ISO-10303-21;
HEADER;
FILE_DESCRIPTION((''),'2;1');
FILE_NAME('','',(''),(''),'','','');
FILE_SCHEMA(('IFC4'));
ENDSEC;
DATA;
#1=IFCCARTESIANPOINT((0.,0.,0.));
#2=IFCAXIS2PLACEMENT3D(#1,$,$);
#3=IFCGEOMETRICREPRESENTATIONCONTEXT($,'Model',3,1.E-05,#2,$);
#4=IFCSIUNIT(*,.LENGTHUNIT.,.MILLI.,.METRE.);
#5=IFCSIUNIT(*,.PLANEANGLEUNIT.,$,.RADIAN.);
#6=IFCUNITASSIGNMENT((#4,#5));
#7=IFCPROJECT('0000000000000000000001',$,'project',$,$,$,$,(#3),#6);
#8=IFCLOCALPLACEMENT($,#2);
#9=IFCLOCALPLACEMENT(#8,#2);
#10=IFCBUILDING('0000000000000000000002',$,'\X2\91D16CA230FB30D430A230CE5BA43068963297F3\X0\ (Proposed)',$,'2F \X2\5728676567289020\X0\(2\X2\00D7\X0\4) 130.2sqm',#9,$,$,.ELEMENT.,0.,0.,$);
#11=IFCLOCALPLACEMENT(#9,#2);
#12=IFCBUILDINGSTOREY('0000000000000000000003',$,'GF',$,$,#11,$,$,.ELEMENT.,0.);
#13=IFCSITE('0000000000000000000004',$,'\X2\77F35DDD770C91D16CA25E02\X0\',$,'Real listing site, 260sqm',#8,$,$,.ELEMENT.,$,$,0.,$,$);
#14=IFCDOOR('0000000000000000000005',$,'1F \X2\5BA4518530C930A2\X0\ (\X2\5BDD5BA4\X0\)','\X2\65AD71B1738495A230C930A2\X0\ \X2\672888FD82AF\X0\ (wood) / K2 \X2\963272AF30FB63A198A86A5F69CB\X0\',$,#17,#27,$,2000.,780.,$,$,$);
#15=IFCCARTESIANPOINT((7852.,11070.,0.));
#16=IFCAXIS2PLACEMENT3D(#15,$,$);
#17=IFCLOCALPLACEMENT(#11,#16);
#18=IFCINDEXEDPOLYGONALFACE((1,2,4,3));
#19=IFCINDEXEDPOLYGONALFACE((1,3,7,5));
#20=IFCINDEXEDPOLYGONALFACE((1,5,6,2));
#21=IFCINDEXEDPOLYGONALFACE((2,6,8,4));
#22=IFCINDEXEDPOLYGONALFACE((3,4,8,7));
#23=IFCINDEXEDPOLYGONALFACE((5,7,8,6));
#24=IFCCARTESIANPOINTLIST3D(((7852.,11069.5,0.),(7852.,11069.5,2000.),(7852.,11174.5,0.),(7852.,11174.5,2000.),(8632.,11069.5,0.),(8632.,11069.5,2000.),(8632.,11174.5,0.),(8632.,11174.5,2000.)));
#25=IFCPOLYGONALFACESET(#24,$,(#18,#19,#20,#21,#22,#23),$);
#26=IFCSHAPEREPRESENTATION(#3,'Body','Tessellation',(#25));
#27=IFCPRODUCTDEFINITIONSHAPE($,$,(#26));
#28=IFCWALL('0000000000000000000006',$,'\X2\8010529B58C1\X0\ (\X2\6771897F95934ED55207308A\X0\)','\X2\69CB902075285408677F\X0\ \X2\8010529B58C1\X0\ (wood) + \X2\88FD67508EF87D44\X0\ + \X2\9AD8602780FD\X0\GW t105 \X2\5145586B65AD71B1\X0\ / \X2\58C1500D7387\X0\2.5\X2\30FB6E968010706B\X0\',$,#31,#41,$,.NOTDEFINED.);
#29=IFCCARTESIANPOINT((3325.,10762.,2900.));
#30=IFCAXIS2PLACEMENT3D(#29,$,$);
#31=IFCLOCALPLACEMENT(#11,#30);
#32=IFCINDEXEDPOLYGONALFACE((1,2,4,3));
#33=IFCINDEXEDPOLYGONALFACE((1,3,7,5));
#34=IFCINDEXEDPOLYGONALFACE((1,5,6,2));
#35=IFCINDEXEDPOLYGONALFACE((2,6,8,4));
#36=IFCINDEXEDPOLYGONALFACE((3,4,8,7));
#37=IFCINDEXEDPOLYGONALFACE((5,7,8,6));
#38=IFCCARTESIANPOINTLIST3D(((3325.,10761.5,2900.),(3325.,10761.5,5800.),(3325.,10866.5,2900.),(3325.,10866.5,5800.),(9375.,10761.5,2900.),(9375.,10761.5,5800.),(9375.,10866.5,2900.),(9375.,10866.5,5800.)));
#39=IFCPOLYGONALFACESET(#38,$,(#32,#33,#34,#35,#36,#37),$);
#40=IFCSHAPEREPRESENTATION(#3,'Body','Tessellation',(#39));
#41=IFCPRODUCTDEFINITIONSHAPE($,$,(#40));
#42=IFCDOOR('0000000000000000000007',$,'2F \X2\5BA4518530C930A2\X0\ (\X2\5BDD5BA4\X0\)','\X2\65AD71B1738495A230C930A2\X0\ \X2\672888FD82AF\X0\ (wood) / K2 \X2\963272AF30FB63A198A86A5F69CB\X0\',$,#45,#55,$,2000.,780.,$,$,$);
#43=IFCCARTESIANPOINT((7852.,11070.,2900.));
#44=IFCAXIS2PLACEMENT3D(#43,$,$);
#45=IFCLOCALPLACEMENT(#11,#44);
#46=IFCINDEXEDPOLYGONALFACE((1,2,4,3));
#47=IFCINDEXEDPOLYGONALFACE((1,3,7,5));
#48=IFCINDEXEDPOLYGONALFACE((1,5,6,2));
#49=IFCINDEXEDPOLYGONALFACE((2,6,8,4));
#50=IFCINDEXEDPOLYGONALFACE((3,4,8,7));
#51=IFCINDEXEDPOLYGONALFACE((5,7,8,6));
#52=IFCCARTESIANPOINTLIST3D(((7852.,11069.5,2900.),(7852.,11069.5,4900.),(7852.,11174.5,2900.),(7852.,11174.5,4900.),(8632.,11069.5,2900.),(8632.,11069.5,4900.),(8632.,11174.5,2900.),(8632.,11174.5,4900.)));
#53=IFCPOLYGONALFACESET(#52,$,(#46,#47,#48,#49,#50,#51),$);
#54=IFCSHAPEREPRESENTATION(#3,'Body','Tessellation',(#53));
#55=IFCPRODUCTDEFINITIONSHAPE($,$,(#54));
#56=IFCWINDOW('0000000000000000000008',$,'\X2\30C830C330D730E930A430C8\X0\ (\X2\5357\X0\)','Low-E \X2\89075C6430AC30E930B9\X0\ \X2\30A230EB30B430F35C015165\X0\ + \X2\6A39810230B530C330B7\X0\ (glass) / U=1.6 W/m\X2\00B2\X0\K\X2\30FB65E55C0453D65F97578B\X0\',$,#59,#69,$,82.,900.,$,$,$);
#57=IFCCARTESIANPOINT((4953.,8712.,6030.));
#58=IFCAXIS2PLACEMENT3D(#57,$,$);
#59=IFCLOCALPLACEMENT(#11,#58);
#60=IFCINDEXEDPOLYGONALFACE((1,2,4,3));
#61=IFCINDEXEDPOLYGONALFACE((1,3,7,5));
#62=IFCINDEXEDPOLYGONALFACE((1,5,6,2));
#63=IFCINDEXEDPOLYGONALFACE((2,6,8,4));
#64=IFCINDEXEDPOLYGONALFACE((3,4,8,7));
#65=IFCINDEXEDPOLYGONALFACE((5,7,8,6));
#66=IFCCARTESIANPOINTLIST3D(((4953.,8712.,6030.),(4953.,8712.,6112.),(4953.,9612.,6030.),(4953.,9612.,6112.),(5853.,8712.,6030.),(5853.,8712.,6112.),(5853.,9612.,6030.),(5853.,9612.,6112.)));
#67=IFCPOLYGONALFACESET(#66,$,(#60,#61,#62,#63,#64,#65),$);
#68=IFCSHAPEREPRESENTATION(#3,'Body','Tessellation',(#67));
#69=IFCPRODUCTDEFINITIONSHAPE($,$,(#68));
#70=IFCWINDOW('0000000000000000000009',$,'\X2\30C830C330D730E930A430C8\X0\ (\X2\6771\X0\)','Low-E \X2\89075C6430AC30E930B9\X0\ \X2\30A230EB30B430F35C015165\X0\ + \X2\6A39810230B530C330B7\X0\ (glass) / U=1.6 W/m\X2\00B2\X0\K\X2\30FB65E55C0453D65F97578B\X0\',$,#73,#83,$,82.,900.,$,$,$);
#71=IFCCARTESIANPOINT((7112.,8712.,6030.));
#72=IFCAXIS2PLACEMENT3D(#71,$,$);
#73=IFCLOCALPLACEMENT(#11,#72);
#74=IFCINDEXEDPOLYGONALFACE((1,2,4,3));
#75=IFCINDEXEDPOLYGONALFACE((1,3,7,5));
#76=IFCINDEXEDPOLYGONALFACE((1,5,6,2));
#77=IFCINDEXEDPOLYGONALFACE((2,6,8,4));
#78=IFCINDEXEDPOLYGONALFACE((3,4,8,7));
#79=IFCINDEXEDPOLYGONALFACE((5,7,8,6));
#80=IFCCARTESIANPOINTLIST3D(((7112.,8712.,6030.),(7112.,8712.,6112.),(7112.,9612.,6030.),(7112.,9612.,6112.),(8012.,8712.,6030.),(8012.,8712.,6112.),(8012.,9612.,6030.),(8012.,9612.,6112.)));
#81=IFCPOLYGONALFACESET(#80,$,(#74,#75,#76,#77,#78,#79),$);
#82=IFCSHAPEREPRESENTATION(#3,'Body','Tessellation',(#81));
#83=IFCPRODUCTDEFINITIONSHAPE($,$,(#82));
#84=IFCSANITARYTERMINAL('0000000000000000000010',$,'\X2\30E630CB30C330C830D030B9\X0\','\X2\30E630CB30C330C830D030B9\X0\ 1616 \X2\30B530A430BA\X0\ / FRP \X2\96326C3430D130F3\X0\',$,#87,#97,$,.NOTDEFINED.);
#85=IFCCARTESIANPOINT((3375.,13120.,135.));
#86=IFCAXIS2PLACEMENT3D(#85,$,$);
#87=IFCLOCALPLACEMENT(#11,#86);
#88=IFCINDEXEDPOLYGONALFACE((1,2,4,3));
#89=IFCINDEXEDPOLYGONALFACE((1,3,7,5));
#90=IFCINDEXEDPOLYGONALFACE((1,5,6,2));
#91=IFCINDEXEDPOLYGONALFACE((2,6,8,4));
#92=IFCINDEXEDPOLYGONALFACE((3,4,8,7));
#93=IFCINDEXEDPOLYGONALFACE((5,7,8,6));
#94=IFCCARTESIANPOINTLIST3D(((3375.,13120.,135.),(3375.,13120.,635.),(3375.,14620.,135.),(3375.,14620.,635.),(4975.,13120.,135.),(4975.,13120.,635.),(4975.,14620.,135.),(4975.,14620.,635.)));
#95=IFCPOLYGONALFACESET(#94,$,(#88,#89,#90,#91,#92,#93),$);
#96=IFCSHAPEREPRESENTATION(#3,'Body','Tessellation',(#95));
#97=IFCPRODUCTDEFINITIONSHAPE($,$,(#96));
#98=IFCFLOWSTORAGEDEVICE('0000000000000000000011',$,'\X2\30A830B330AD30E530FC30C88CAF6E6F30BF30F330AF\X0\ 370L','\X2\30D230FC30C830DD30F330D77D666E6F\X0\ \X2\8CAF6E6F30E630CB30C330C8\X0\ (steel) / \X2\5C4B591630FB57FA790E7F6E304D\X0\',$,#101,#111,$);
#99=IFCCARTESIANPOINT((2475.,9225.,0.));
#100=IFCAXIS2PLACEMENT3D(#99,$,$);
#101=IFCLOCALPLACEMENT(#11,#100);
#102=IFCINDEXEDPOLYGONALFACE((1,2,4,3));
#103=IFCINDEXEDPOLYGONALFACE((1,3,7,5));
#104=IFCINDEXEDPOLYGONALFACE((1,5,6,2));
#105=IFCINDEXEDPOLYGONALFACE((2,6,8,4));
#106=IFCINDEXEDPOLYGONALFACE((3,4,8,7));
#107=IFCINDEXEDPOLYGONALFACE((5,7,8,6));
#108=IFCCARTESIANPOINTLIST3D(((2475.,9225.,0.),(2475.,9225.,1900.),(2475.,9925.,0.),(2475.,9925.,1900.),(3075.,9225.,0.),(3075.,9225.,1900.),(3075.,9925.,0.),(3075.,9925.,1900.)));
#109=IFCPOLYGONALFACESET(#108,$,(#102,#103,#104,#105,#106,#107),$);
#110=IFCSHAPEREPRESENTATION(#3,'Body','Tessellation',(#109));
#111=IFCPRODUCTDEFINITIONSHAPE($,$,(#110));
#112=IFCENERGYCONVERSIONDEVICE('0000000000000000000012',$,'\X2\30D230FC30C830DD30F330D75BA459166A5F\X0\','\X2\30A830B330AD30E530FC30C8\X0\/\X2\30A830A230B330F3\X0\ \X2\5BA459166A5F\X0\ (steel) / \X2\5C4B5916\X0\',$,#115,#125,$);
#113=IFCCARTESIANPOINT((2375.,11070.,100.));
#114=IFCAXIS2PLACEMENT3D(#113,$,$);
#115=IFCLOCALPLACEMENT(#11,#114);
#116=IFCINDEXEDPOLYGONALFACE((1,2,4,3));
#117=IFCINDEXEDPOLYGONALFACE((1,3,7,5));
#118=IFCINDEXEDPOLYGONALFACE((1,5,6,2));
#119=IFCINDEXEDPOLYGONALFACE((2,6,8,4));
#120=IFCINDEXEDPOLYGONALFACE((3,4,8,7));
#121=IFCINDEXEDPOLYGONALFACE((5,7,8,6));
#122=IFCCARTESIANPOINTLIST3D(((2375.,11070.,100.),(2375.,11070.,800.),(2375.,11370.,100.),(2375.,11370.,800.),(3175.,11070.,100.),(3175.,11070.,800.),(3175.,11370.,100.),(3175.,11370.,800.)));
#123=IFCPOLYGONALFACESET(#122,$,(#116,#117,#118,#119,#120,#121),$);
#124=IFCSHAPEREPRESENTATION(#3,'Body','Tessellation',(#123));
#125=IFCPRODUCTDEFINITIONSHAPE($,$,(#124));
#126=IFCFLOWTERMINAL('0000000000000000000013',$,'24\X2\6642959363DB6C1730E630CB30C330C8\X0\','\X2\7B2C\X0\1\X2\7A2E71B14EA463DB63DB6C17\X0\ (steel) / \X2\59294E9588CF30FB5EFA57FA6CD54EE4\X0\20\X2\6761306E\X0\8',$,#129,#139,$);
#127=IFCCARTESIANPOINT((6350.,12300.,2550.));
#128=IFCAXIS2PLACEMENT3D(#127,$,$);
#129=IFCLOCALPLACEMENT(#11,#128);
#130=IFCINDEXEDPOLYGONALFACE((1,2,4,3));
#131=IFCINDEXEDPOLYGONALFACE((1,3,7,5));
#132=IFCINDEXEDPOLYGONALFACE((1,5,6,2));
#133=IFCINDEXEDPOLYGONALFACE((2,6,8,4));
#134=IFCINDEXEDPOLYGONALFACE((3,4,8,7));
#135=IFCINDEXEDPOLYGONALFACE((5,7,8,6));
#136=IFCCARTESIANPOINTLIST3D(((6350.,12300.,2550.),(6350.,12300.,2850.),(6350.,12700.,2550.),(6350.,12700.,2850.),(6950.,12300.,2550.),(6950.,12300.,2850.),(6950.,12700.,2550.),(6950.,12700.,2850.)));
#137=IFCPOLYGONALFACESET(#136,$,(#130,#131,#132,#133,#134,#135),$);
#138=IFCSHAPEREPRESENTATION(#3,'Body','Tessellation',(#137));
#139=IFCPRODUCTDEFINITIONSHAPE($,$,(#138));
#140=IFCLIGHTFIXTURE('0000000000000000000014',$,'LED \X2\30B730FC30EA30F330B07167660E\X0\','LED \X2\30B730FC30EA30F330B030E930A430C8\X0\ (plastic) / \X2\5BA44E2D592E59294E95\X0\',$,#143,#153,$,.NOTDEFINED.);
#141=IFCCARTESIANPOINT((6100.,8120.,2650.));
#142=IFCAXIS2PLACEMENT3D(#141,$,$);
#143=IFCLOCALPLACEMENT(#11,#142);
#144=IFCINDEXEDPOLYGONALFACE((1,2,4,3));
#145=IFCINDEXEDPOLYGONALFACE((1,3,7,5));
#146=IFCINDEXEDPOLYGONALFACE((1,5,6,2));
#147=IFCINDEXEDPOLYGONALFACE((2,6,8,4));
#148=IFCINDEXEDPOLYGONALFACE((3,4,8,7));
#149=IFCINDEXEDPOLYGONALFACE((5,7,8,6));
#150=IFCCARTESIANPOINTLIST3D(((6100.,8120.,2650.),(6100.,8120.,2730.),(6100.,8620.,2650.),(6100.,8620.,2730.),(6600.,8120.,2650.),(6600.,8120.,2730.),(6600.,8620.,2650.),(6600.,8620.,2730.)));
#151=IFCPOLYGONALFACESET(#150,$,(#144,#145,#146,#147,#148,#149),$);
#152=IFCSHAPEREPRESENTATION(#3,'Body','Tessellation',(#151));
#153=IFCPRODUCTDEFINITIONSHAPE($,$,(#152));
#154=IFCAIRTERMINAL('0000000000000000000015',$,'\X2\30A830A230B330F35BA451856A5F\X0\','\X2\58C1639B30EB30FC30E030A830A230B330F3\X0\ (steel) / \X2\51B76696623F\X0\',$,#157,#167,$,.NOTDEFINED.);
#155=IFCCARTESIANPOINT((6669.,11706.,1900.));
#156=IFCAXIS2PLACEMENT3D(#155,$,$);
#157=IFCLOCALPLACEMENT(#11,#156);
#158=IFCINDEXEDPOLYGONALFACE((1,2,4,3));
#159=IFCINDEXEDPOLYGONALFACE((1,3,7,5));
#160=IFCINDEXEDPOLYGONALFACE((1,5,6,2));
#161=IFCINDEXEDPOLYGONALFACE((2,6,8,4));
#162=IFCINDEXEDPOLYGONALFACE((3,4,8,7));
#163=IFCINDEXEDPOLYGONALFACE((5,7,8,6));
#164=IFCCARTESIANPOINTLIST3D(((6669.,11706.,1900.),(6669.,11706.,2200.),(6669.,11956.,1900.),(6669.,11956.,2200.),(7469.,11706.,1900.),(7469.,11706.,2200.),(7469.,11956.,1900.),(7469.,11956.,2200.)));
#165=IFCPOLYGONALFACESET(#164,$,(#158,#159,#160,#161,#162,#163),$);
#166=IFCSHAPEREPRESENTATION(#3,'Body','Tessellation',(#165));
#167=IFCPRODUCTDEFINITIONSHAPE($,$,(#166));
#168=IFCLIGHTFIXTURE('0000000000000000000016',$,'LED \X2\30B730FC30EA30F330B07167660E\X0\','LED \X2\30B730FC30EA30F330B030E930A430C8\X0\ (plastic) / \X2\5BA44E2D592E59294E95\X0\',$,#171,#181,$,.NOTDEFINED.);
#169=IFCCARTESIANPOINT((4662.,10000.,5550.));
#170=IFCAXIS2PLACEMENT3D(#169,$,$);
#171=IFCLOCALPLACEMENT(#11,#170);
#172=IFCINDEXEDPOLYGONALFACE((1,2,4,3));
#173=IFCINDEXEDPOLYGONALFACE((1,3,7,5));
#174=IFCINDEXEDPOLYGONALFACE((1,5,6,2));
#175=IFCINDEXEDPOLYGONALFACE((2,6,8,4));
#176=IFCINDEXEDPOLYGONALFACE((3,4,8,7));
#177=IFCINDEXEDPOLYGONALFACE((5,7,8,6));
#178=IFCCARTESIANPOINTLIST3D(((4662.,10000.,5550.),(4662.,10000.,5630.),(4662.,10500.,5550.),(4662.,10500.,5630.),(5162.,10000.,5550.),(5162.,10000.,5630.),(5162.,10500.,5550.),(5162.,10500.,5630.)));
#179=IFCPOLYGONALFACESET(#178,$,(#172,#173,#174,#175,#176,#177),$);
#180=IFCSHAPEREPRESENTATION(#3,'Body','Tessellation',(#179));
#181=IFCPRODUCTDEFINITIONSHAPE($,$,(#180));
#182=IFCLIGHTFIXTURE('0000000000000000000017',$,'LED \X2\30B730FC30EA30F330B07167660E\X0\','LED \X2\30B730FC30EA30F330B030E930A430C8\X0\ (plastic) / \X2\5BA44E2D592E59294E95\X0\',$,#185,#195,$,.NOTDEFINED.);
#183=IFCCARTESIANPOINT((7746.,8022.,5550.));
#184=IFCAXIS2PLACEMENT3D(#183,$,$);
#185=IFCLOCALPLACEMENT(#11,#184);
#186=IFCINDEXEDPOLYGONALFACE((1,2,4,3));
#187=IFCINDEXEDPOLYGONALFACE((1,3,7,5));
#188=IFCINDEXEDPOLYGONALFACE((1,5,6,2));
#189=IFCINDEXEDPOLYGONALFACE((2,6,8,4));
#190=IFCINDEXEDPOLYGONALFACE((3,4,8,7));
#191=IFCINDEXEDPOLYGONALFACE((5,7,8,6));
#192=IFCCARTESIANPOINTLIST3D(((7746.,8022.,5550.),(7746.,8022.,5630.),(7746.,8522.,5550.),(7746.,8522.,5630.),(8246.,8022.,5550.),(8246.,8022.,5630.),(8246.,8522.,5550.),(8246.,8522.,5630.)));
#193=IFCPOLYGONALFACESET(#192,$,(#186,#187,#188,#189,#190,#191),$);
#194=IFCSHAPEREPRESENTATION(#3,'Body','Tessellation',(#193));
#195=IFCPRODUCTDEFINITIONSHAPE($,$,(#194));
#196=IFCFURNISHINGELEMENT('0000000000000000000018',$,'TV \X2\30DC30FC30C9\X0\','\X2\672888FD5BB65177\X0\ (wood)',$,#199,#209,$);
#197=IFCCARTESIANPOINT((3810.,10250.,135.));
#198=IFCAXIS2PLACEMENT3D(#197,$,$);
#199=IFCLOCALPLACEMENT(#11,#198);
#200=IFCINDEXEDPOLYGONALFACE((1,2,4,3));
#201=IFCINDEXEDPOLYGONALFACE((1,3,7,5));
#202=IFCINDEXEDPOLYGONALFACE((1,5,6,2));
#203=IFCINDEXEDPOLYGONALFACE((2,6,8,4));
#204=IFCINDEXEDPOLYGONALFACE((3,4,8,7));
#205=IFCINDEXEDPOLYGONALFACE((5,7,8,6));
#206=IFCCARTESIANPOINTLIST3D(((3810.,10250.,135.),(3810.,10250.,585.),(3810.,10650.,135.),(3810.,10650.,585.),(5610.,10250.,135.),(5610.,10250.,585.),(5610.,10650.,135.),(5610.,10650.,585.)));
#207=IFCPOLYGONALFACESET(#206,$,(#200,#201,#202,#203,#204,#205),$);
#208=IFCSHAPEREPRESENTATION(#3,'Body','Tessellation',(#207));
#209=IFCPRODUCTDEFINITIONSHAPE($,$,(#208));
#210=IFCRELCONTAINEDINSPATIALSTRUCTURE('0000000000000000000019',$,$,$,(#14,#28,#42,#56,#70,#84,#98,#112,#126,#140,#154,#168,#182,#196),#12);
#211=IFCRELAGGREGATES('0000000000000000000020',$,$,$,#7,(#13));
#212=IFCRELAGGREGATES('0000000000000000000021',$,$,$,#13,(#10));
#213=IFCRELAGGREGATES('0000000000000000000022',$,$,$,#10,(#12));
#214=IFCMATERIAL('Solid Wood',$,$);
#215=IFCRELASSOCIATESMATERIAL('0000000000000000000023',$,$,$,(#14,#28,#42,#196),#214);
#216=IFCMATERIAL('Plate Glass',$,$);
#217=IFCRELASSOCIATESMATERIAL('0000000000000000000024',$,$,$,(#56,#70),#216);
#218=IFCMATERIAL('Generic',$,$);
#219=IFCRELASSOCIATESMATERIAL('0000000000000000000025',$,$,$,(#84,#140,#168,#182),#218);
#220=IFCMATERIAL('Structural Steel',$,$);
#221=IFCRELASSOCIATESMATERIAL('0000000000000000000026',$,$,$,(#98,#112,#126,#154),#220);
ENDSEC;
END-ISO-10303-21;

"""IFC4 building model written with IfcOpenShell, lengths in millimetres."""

from ifc_helpers import new_model, si_unit, frame, frame_2d, origin, place, context, project, spatial, rectangle, extrude, material, element, save


model = new_model("IFC4")

# Units and contexts
model_context = context("Model", 3, precision=1e-05, world=origin())
ifc_project = project(units=[si_unit("LENGTHUNIT", "METRE", prefix="MILLI"), si_unit("PLANEANGLEUNIT", "RADIAN")], contexts=[model_context])

# Site, building, storey
site_placement = place(None, origin())
site = spatial("IfcSite", under=ifc_project, at=site_placement, Name="石川県金沢市", ObjectType="Real listing site, 260sqm", CompositionType="ELEMENT", RefElevation=0.0)
building_placement = place(site_placement, origin())
building = spatial("IfcBuilding", under=site, at=building_placement, Name="金沢・ピアノ室と防音 (Proposed)", ObjectType="2F 在来木造(2×4) 130.2sqm", CompositionType="ELEMENT", ElevationOfRefHeight=0.0, ElevationOfTerrain=0.0)
storey_placement = place(building_placement, origin())
storey = spatial("IfcBuildingStorey", under=building, at=storey_placement, Name="GF", CompositionType="ELEMENT", Elevation=0.0)

# Shared definitions
ifc_material_1 = material(Name="Solid Wood")

# Door
door_1_placement = place(storey_placement, frame((7852.0, 11070.0, 0.0)))
element("IfcDoor", 1, at=door_1_placement, inside=storey, material=ifc_material_1, Name="1F 室内ドア (寝室)", Description="断熱玄関ドア 木製芯 (wood) / K2 防犯・採風機構", OverallHeight=2000.0, OverallWidth=780.0, context=model_context, shape_type="SweptSolid", body=[
    extrude(rectangle(XDim=780.0, YDim=105.0, at=frame_2d((390.0, 52.0))), frame((7852.0, 11070.0, 0.0)), (0.0, 0.0, 1.0), 2000.0),
])

# Wall
wall_1_placement = place(storey_placement, frame((3325.0, 10762.0, 2900.0)))
element("IfcWall", 2, at=wall_1_placement, inside=storey, material=ifc_material_1, Name="耐力壁 (東西間仕切り)", Description="構造用合板 耐力壁 (wood) + 製材軸組 + 高性能GW t105 充填断熱 / 壁倍率2.5・準耐火", PredefinedType="NOTDEFINED", context=model_context, shape_type="SweptSolid", body=[
    extrude(rectangle(XDim=6050.0, YDim=105.0, at=frame_2d((3025.0, 52.0))), frame((3325.0, 10762.0, 2900.0)), (0.0, 0.0, 1.0), 2900.0),
])

# Door
door_2_placement = place(storey_placement, frame((7852.0, 11070.0, 2900.0)))
element("IfcDoor", 3, at=door_2_placement, inside=storey, material=ifc_material_1, Name="2F 室内ドア (寝室)", Description="断熱玄関ドア 木製芯 (wood) / K2 防犯・採風機構", OverallHeight=2000.0, OverallWidth=780.0, context=model_context, shape_type="SweptSolid", body=[
    extrude(rectangle(XDim=780.0, YDim=105.0, at=frame_2d((390.0, 52.0))), frame((7852.0, 11070.0, 2900.0)), (0.0, 0.0, 1.0), 2000.0),
])

# Windows
ifc_material_2 = material(Name="Plate Glass")
window_1_placement = place(storey_placement, frame((4953.0, 8712.0, 6030.0)))
element("IfcWindow", 4, at=window_1_placement, inside=storey, material=ifc_material_2, Name="トップライト (南)", Description="Low-E 複層ガラス アルゴン封入 + 樹脂サッシ (glass) / U=1.6 W/m²K・日射取得型", OverallHeight=82.0, OverallWidth=900.0, context=model_context, shape_type="SweptSolid", body=[
    extrude(rectangle(XDim=900.0, YDim=900.0, at=frame_2d((450.0, 450.0))), frame((4953.0, 8712.0, 6030.0)), (0.0, 0.0, 1.0), 82.0),
])
window_2_placement = place(storey_placement, frame((7112.0, 8712.0, 6030.0)))
element("IfcWindow", 5, at=window_2_placement, inside=storey, material=ifc_material_2, Name="トップライト (東)", Description="Low-E 複層ガラス アルゴン封入 + 樹脂サッシ (glass) / U=1.6 W/m²K・日射取得型", OverallHeight=82.0, OverallWidth=900.0, context=model_context, shape_type="SweptSolid", body=[
    extrude(rectangle(XDim=900.0, YDim=900.0, at=frame_2d((450.0, 450.0))), frame((7112.0, 8712.0, 6030.0)), (0.0, 0.0, 1.0), 82.0),
])

# Sanitary terminal
ifc_material_3 = material(Name="Generic")
sanitary_terminal_placement = place(storey_placement, frame((3375.0, 13120.0, 135.0)))
element("IfcSanitaryTerminal", 6, at=sanitary_terminal_placement, inside=storey, material=ifc_material_3, Name="ユニットバス", Description="ユニットバス 1616 サイズ / FRP 防水パン", PredefinedType="NOTDEFINED", context=model_context, shape_type="SweptSolid", body=[
    extrude(rectangle(XDim=1600.0, YDim=1500.0, at=frame_2d((800.0, 750.0))), frame((3375.0, 13120.0, 135.0)), (0.0, 0.0, 1.0), 500.0),
])

# Flow storage device
ifc_material_4 = material(Name="Structural Steel")
flow_storage_device_placement = place(storey_placement, frame((2475.0, 9225.0, 0.0)))
element("IfcFlowStorageDevice", 7, at=flow_storage_device_placement, inside=storey, material=ifc_material_4, Name="エコキュート貯湯タンク 370L", Description="ヒートポンプ給湯 貯湯ユニット (steel) / 屋外・基礎置き", context=model_context, shape_type="SweptSolid", body=[
    extrude(rectangle(XDim=600.0, YDim=700.0, at=frame_2d((300.0, 350.0))), frame((2475.0, 9225.0, 0.0)), (0.0, 0.0, 1.0), 1900.0),
])

# Energy conversion device
energy_conversion_device_placement = place(storey_placement, frame((2375.0, 11070.0, 100.0)))
element("IfcEnergyConversionDevice", 8, at=energy_conversion_device_placement, inside=storey, material=ifc_material_4, Name="ヒートポンプ室外機", Description="エコキュート/エアコン 室外機 (steel) / 屋外", context=model_context, shape_type="SweptSolid", body=[
    extrude(rectangle(XDim=800.0, YDim=300.0, at=frame_2d((400.0, 150.0))), frame((2375.0, 11070.0, 100.0)), (0.0, 0.0, 1.0), 700.0),
])

# Flow terminal
flow_terminal_placement = place(storey_placement, frame((6350.0, 12300.0, 2550.0)))
element("IfcFlowTerminal", 9, at=flow_terminal_placement, inside=storey, material=ifc_material_4, Name="24時間換気ユニット", Description="第1種熱交換換気 (steel) / 天井裏・建基法令20条の8", context=model_context, shape_type="SweptSolid", body=[
    extrude(rectangle(XDim=600.0, YDim=400.0, at=frame_2d((300.0, 200.0))), frame((6350.0, 12300.0, 2550.0)), (0.0, 0.0, 1.0), 300.0),
])

# Light fixture
light_fixture_1_placement = place(storey_placement, frame((6100.0, 8120.0, 2650.0)))
element("IfcLightFixture", 10, at=light_fixture_1_placement, inside=storey, material=ifc_material_3, Name="LED シーリング照明", Description="LED シーリングライト (plastic) / 室中央天井", PredefinedType="NOTDEFINED", context=model_context, shape_type="SweptSolid", body=[
    extrude(rectangle(XDim=500.0, YDim=500.0, at=frame_2d((250.0, 250.0))), frame((6100.0, 8120.0, 2650.0)), (0.0, 0.0, 1.0), 80.0),
])

# Air terminal
air_terminal_placement = place(storey_placement, frame((6669.0, 11706.0, 1900.0)))
element("IfcAirTerminal", 11, at=air_terminal_placement, inside=storey, material=ifc_material_4, Name="エアコン室内機", Description="壁掛ルームエアコン (steel) / 冷暖房", PredefinedType="NOTDEFINED", context=model_context, shape_type="SweptSolid", body=[
    extrude(rectangle(XDim=800.0, YDim=250.0, at=frame_2d((400.0, 125.0))), frame((6669.0, 11706.0, 1900.0)), (0.0, 0.0, 1.0), 300.0),
])

# Light fixtures
light_fixture_2_placement = place(storey_placement, frame((4662.0, 10000.0, 5550.0)))
element("IfcLightFixture", 12, at=light_fixture_2_placement, inside=storey, material=ifc_material_3, Name="LED シーリング照明", Description="LED シーリングライト (plastic) / 室中央天井", PredefinedType="NOTDEFINED", context=model_context, shape_type="SweptSolid", body=[
    extrude(rectangle(XDim=500.0, YDim=500.0, at=frame_2d((250.0, 250.0))), frame((4662.0, 10000.0, 5550.0)), (0.0, 0.0, 1.0), 80.0),
])
light_fixture_3_placement = place(storey_placement, frame((7746.0, 8022.0, 5550.0)))
element("IfcLightFixture", 13, at=light_fixture_3_placement, inside=storey, material=ifc_material_3, Name="LED シーリング照明", Description="LED シーリングライト (plastic) / 室中央天井", PredefinedType="NOTDEFINED", context=model_context, shape_type="SweptSolid", body=[
    extrude(rectangle(XDim=500.0, YDim=500.0, at=frame_2d((250.0, 250.0))), frame((7746.0, 8022.0, 5550.0)), (0.0, 0.0, 1.0), 80.0),
])

# Furnishing element
furnishing_1_placement = place(storey_placement, frame((3810.0, 10250.0, 135.0)))
element("IfcFurnishingElement", 14, at=furnishing_1_placement, inside=storey, material=ifc_material_1, Name="TV ボード", Description="木製家具 (wood)", context=model_context, shape_type="SweptSolid", body=[
    extrude(rectangle(XDim=1800.0, YDim=400.0, at=frame_2d((900.0, 200.0))), frame((3810.0, 10250.0, 135.0)), (0.0, 0.0, 1.0), 450.0),
])

save(model, "model.ifc")
